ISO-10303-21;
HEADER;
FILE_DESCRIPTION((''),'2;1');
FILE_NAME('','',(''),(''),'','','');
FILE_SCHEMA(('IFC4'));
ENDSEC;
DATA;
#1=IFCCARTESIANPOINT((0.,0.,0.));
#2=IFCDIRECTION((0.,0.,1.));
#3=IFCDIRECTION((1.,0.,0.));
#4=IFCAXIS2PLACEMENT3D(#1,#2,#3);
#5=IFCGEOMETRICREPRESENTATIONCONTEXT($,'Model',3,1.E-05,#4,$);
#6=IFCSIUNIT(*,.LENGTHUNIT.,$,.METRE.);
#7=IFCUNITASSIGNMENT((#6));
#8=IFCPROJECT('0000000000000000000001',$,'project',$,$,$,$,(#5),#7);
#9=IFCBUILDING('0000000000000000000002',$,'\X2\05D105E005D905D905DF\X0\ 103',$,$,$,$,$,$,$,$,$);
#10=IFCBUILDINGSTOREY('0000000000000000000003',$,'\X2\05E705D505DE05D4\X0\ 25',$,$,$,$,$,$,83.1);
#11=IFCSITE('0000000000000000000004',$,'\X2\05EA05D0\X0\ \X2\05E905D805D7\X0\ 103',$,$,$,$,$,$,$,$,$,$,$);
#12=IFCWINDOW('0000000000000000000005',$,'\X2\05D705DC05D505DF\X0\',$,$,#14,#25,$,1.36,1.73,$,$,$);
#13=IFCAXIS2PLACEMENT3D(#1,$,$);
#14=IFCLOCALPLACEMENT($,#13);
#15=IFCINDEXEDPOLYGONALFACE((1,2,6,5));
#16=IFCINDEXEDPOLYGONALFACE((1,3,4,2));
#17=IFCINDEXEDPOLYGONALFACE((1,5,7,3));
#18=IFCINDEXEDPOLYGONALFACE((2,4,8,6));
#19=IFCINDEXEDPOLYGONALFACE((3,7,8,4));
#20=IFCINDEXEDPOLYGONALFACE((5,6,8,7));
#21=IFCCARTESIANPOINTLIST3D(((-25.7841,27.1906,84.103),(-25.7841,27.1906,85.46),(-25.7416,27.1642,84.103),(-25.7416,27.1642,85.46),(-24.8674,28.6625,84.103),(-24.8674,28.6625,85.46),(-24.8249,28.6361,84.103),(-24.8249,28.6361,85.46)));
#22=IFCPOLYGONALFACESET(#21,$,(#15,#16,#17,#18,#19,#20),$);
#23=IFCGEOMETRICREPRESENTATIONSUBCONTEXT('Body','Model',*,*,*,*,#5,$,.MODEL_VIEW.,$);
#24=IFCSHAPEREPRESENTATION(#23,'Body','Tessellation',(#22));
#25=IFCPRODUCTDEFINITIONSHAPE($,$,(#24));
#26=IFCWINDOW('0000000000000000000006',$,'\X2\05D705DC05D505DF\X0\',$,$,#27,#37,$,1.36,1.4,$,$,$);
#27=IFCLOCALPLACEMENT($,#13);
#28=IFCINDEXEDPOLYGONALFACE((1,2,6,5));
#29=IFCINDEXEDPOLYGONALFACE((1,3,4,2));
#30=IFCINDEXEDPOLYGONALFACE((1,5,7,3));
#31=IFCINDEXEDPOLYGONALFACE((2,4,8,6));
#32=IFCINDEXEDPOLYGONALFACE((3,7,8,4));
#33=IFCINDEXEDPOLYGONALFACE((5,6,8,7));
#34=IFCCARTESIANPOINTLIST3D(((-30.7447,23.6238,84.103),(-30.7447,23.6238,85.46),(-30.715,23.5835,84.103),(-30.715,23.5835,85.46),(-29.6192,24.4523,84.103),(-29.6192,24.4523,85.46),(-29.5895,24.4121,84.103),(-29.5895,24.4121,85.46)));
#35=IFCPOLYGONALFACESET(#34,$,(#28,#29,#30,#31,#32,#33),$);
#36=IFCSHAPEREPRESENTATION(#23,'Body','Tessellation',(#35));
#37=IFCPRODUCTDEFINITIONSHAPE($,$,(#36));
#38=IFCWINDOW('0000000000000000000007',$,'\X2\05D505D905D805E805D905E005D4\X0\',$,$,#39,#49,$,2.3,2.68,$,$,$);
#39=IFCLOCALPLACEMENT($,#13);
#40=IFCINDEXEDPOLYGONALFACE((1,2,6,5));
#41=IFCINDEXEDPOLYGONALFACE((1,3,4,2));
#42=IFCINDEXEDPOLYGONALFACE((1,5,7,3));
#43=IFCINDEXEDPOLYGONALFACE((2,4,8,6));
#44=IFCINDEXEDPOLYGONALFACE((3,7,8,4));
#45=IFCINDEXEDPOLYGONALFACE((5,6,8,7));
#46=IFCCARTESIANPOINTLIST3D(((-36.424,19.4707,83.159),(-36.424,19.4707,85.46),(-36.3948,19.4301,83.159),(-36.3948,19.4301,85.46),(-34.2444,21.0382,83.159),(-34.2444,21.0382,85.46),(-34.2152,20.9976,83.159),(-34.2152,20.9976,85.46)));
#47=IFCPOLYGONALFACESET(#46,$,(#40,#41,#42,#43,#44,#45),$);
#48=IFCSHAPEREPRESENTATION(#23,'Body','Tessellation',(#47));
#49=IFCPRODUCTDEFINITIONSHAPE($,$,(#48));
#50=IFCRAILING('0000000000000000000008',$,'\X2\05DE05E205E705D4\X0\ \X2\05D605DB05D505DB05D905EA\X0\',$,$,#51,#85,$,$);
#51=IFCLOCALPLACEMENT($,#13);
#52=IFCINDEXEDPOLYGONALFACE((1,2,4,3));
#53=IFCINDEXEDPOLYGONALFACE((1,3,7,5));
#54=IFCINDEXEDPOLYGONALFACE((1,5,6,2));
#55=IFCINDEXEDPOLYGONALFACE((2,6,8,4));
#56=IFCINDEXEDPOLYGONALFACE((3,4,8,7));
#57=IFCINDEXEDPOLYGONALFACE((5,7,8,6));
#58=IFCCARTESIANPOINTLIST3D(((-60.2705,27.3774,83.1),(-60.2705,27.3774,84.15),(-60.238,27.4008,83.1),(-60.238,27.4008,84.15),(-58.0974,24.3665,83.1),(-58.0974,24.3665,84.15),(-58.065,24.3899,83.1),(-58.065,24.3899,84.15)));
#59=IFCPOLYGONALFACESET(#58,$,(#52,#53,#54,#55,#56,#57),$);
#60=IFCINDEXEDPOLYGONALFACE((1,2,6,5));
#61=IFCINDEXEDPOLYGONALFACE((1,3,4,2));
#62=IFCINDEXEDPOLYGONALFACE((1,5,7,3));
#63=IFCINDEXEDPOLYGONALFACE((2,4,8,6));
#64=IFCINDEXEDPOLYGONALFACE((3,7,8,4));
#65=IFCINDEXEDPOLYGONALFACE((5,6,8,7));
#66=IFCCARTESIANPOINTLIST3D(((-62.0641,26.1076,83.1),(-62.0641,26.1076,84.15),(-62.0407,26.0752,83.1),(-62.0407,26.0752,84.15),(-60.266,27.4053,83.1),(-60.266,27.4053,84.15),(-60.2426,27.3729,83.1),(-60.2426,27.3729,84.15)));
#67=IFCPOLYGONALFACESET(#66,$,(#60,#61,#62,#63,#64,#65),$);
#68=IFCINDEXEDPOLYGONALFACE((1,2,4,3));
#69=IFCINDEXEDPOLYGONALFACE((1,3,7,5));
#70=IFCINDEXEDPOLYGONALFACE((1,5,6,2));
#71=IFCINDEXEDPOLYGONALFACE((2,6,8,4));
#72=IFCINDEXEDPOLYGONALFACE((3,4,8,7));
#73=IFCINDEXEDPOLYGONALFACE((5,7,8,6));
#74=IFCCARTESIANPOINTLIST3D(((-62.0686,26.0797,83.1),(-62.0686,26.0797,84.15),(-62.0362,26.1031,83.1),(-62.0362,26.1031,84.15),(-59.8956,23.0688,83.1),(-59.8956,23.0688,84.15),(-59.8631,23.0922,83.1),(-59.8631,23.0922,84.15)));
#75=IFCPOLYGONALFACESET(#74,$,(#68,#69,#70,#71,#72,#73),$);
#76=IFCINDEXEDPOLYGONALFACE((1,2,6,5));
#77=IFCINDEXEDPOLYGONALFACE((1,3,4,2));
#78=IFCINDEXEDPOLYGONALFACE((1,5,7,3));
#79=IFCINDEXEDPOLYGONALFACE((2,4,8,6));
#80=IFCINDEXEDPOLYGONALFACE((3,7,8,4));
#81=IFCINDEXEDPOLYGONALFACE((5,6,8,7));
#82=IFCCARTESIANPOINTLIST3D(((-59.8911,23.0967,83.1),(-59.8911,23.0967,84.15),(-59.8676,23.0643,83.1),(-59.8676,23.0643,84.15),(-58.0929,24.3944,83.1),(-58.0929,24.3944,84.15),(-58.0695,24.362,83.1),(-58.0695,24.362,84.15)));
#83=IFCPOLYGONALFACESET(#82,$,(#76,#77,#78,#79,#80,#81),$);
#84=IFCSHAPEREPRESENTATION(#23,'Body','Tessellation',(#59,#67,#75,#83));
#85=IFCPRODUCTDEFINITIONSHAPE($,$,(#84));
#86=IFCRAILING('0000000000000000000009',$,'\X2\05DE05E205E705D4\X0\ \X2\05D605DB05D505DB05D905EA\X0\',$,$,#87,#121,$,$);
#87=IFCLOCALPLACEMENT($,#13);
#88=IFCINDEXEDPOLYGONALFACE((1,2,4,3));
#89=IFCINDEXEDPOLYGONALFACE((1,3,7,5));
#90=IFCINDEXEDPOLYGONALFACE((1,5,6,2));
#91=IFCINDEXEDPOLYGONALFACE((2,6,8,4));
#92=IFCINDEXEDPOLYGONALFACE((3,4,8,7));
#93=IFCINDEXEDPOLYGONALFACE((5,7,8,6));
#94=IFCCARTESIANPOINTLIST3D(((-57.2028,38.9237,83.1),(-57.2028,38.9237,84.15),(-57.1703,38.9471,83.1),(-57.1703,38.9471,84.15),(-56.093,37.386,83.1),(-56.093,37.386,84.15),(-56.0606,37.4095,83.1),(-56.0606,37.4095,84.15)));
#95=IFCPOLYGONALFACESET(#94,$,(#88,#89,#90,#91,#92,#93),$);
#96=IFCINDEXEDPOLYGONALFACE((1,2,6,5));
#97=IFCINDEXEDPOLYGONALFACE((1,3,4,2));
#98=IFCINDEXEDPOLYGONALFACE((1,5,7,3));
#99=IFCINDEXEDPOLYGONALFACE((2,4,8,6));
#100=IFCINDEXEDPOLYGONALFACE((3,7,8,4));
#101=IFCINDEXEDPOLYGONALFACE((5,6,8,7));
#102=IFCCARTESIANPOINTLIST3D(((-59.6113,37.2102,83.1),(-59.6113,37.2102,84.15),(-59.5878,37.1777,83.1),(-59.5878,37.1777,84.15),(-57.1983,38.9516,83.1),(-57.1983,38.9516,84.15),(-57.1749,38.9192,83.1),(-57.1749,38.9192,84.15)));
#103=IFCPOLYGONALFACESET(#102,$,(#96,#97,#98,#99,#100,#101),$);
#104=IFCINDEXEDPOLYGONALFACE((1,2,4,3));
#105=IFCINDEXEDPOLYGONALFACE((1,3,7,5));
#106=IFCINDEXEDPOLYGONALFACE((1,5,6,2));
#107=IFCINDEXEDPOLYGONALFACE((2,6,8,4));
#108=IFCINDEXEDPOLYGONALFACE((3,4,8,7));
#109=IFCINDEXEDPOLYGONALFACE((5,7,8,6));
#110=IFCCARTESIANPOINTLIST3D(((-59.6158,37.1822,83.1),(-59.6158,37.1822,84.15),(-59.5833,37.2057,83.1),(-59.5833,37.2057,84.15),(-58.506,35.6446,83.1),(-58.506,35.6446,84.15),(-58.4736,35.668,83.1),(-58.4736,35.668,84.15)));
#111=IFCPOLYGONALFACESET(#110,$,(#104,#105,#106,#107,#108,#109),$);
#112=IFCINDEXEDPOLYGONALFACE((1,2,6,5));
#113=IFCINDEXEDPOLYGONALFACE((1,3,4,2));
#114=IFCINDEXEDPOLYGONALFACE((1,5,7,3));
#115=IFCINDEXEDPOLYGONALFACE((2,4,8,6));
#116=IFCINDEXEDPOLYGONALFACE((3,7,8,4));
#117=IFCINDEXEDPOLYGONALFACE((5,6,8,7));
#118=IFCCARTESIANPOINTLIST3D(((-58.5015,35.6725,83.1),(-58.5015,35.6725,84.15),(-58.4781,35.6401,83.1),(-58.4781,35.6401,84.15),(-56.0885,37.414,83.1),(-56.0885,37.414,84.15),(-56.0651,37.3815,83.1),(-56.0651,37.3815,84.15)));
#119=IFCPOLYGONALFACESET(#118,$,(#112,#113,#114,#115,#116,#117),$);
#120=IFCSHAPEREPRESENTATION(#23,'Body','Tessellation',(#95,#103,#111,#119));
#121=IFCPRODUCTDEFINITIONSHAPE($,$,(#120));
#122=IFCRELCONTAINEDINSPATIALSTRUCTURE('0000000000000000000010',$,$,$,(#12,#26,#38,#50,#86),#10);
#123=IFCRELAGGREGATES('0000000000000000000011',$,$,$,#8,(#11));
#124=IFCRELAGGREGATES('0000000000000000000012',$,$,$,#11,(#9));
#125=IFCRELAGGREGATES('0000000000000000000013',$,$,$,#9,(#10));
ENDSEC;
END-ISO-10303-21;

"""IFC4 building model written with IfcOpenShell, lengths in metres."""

from ifc_helpers import new_model, si_unit, frame, origin_with_axes, context, subcontext, project, spatial, polyline, outline, extrude, element, save


model = new_model("IFC4")

# Units and contexts
model_context = context("Model", 3, precision=1e-05, world=origin_with_axes())
body_context = subcontext(model_context, "Body", "Model", "MODEL_VIEW")
ifc_project = project(units=[si_unit("LENGTHUNIT", "METRE")], contexts=[model_context])

# Site, building, storey
site = spatial("IfcSite", under=ifc_project, Name="תא שטח 103")
building = spatial("IfcBuilding", under=site, Name="בניין 103")
storey = spatial("IfcBuildingStorey", under=building, Name="קומה 25", Elevation=83.1)

# Windows
element("IfcWindow", 1, inside=storey, Name="חלון", OverallHeight=1.36, OverallWidth=1.73, context=body_context, shape_type="SweptSolid", body=[
    extrude(outline(polyline([(-24.8674, 28.6625), (-25.7841, 27.1906), (-25.7416, 27.1642), (-24.8249, 28.6361), (-24.8674, 28.6625)])), frame((0.0, 0.0, 84.103)), (0.0, 0.0, 1.0), 1.357),
])
element("IfcWindow", 2, inside=storey, Name="חלון", OverallHeight=1.36, OverallWidth=1.4, context=body_context, shape_type="SweptSolid", body=[
    extrude(outline(polyline([(-29.6192, 24.4523), (-30.7447, 23.6238), (-30.715, 23.5835), (-29.5895, 24.4121), (-29.6192, 24.4523)])), frame((0.0, 0.0, 84.103)), (0.0, 0.0, 1.0), 1.357),
])
element("IfcWindow", 3, inside=storey, Name="ויטרינה", OverallHeight=2.3, OverallWidth=2.68, context=body_context, shape_type="SweptSolid", body=[
    extrude(outline(polyline([(-34.2444, 21.0382), (-36.424, 19.4707), (-36.3948, 19.4301), (-34.2152, 20.9976), (-34.2444, 21.0382)])), frame((0.0, 0.0, 83.159)), (0.0, 0.0, 1.0), 2.301),
])

# Railings
element("IfcRailing", 4, inside=storey, Name="מעקה זכוכית", context=body_context, shape_type="SweptSolid", body=[
    extrude(outline(polyline([(-58.065, 24.3899), (-60.238, 27.4008), (-60.2705, 27.3774), (-58.0974, 24.3665), (-58.065, 24.3899)])), frame((0.0, 0.0, 83.1)), (0.0, 0.0, 1.0), 1.05),
    extrude(outline(polyline([(-60.266, 27.4053), (-62.0641, 26.1076), (-62.0407, 26.0752), (-60.2426, 27.3729), (-60.266, 27.4053)])), frame((0.0, 0.0, 83.1)), (0.0, 0.0, 1.0), 1.05),
    extrude(outline(polyline([(-62.0686, 26.0797), (-59.8956, 23.0688), (-59.8631, 23.0922), (-62.0362, 26.1031), (-62.0686, 26.0797)])), frame((0.0, 0.0, 83.1)), (0.0, 0.0, 1.0), 1.05),
    extrude(outline(polyline([(-59.8676, 23.0643), (-58.0695, 24.362), (-58.0929, 24.3944), (-59.8911, 23.0967), (-59.8676, 23.0643)])), frame((0.0, 0.0, 83.1)), (0.0, 0.0, 1.0), 1.05),
])
element("IfcRailing", 5, inside=storey, Name="מעקה זכוכית", context=body_context, shape_type="SweptSolid", body=[
    extrude(outline(polyline([(-56.0606, 37.4095), (-57.1703, 38.9471), (-57.2028, 38.9237), (-56.093, 37.386), (-56.0606, 37.4095)])), frame((0.0, 0.0, 83.1)), (0.0, 0.0, 1.0), 1.05),
    extrude(outline(polyline([(-57.1983, 38.9516), (-59.6113, 37.2102), (-59.5878, 37.1777), (-57.1749, 38.9192), (-57.1983, 38.9516)])), frame((0.0, 0.0, 83.1)), (0.0, 0.0, 1.0), 1.05),
    extrude(outline(polyline([(-59.6158, 37.1822), (-58.506, 35.6446), (-58.4736, 35.668), (-59.5833, 37.2057), (-59.6158, 37.1822)])), frame((0.0, 0.0, 83.1)), (0.0, 0.0, 1.0), 1.05),
    extrude(outline(polyline([(-58.4781, 35.6401), (-56.0651, 37.3815), (-56.0885, 37.414), (-58.5015, 35.6725), (-58.4781, 35.6401)])), frame((0.0, 0.0, 83.1)), (0.0, 0.0, 1.0), 1.05),
])

save(model, "model.ifc")
